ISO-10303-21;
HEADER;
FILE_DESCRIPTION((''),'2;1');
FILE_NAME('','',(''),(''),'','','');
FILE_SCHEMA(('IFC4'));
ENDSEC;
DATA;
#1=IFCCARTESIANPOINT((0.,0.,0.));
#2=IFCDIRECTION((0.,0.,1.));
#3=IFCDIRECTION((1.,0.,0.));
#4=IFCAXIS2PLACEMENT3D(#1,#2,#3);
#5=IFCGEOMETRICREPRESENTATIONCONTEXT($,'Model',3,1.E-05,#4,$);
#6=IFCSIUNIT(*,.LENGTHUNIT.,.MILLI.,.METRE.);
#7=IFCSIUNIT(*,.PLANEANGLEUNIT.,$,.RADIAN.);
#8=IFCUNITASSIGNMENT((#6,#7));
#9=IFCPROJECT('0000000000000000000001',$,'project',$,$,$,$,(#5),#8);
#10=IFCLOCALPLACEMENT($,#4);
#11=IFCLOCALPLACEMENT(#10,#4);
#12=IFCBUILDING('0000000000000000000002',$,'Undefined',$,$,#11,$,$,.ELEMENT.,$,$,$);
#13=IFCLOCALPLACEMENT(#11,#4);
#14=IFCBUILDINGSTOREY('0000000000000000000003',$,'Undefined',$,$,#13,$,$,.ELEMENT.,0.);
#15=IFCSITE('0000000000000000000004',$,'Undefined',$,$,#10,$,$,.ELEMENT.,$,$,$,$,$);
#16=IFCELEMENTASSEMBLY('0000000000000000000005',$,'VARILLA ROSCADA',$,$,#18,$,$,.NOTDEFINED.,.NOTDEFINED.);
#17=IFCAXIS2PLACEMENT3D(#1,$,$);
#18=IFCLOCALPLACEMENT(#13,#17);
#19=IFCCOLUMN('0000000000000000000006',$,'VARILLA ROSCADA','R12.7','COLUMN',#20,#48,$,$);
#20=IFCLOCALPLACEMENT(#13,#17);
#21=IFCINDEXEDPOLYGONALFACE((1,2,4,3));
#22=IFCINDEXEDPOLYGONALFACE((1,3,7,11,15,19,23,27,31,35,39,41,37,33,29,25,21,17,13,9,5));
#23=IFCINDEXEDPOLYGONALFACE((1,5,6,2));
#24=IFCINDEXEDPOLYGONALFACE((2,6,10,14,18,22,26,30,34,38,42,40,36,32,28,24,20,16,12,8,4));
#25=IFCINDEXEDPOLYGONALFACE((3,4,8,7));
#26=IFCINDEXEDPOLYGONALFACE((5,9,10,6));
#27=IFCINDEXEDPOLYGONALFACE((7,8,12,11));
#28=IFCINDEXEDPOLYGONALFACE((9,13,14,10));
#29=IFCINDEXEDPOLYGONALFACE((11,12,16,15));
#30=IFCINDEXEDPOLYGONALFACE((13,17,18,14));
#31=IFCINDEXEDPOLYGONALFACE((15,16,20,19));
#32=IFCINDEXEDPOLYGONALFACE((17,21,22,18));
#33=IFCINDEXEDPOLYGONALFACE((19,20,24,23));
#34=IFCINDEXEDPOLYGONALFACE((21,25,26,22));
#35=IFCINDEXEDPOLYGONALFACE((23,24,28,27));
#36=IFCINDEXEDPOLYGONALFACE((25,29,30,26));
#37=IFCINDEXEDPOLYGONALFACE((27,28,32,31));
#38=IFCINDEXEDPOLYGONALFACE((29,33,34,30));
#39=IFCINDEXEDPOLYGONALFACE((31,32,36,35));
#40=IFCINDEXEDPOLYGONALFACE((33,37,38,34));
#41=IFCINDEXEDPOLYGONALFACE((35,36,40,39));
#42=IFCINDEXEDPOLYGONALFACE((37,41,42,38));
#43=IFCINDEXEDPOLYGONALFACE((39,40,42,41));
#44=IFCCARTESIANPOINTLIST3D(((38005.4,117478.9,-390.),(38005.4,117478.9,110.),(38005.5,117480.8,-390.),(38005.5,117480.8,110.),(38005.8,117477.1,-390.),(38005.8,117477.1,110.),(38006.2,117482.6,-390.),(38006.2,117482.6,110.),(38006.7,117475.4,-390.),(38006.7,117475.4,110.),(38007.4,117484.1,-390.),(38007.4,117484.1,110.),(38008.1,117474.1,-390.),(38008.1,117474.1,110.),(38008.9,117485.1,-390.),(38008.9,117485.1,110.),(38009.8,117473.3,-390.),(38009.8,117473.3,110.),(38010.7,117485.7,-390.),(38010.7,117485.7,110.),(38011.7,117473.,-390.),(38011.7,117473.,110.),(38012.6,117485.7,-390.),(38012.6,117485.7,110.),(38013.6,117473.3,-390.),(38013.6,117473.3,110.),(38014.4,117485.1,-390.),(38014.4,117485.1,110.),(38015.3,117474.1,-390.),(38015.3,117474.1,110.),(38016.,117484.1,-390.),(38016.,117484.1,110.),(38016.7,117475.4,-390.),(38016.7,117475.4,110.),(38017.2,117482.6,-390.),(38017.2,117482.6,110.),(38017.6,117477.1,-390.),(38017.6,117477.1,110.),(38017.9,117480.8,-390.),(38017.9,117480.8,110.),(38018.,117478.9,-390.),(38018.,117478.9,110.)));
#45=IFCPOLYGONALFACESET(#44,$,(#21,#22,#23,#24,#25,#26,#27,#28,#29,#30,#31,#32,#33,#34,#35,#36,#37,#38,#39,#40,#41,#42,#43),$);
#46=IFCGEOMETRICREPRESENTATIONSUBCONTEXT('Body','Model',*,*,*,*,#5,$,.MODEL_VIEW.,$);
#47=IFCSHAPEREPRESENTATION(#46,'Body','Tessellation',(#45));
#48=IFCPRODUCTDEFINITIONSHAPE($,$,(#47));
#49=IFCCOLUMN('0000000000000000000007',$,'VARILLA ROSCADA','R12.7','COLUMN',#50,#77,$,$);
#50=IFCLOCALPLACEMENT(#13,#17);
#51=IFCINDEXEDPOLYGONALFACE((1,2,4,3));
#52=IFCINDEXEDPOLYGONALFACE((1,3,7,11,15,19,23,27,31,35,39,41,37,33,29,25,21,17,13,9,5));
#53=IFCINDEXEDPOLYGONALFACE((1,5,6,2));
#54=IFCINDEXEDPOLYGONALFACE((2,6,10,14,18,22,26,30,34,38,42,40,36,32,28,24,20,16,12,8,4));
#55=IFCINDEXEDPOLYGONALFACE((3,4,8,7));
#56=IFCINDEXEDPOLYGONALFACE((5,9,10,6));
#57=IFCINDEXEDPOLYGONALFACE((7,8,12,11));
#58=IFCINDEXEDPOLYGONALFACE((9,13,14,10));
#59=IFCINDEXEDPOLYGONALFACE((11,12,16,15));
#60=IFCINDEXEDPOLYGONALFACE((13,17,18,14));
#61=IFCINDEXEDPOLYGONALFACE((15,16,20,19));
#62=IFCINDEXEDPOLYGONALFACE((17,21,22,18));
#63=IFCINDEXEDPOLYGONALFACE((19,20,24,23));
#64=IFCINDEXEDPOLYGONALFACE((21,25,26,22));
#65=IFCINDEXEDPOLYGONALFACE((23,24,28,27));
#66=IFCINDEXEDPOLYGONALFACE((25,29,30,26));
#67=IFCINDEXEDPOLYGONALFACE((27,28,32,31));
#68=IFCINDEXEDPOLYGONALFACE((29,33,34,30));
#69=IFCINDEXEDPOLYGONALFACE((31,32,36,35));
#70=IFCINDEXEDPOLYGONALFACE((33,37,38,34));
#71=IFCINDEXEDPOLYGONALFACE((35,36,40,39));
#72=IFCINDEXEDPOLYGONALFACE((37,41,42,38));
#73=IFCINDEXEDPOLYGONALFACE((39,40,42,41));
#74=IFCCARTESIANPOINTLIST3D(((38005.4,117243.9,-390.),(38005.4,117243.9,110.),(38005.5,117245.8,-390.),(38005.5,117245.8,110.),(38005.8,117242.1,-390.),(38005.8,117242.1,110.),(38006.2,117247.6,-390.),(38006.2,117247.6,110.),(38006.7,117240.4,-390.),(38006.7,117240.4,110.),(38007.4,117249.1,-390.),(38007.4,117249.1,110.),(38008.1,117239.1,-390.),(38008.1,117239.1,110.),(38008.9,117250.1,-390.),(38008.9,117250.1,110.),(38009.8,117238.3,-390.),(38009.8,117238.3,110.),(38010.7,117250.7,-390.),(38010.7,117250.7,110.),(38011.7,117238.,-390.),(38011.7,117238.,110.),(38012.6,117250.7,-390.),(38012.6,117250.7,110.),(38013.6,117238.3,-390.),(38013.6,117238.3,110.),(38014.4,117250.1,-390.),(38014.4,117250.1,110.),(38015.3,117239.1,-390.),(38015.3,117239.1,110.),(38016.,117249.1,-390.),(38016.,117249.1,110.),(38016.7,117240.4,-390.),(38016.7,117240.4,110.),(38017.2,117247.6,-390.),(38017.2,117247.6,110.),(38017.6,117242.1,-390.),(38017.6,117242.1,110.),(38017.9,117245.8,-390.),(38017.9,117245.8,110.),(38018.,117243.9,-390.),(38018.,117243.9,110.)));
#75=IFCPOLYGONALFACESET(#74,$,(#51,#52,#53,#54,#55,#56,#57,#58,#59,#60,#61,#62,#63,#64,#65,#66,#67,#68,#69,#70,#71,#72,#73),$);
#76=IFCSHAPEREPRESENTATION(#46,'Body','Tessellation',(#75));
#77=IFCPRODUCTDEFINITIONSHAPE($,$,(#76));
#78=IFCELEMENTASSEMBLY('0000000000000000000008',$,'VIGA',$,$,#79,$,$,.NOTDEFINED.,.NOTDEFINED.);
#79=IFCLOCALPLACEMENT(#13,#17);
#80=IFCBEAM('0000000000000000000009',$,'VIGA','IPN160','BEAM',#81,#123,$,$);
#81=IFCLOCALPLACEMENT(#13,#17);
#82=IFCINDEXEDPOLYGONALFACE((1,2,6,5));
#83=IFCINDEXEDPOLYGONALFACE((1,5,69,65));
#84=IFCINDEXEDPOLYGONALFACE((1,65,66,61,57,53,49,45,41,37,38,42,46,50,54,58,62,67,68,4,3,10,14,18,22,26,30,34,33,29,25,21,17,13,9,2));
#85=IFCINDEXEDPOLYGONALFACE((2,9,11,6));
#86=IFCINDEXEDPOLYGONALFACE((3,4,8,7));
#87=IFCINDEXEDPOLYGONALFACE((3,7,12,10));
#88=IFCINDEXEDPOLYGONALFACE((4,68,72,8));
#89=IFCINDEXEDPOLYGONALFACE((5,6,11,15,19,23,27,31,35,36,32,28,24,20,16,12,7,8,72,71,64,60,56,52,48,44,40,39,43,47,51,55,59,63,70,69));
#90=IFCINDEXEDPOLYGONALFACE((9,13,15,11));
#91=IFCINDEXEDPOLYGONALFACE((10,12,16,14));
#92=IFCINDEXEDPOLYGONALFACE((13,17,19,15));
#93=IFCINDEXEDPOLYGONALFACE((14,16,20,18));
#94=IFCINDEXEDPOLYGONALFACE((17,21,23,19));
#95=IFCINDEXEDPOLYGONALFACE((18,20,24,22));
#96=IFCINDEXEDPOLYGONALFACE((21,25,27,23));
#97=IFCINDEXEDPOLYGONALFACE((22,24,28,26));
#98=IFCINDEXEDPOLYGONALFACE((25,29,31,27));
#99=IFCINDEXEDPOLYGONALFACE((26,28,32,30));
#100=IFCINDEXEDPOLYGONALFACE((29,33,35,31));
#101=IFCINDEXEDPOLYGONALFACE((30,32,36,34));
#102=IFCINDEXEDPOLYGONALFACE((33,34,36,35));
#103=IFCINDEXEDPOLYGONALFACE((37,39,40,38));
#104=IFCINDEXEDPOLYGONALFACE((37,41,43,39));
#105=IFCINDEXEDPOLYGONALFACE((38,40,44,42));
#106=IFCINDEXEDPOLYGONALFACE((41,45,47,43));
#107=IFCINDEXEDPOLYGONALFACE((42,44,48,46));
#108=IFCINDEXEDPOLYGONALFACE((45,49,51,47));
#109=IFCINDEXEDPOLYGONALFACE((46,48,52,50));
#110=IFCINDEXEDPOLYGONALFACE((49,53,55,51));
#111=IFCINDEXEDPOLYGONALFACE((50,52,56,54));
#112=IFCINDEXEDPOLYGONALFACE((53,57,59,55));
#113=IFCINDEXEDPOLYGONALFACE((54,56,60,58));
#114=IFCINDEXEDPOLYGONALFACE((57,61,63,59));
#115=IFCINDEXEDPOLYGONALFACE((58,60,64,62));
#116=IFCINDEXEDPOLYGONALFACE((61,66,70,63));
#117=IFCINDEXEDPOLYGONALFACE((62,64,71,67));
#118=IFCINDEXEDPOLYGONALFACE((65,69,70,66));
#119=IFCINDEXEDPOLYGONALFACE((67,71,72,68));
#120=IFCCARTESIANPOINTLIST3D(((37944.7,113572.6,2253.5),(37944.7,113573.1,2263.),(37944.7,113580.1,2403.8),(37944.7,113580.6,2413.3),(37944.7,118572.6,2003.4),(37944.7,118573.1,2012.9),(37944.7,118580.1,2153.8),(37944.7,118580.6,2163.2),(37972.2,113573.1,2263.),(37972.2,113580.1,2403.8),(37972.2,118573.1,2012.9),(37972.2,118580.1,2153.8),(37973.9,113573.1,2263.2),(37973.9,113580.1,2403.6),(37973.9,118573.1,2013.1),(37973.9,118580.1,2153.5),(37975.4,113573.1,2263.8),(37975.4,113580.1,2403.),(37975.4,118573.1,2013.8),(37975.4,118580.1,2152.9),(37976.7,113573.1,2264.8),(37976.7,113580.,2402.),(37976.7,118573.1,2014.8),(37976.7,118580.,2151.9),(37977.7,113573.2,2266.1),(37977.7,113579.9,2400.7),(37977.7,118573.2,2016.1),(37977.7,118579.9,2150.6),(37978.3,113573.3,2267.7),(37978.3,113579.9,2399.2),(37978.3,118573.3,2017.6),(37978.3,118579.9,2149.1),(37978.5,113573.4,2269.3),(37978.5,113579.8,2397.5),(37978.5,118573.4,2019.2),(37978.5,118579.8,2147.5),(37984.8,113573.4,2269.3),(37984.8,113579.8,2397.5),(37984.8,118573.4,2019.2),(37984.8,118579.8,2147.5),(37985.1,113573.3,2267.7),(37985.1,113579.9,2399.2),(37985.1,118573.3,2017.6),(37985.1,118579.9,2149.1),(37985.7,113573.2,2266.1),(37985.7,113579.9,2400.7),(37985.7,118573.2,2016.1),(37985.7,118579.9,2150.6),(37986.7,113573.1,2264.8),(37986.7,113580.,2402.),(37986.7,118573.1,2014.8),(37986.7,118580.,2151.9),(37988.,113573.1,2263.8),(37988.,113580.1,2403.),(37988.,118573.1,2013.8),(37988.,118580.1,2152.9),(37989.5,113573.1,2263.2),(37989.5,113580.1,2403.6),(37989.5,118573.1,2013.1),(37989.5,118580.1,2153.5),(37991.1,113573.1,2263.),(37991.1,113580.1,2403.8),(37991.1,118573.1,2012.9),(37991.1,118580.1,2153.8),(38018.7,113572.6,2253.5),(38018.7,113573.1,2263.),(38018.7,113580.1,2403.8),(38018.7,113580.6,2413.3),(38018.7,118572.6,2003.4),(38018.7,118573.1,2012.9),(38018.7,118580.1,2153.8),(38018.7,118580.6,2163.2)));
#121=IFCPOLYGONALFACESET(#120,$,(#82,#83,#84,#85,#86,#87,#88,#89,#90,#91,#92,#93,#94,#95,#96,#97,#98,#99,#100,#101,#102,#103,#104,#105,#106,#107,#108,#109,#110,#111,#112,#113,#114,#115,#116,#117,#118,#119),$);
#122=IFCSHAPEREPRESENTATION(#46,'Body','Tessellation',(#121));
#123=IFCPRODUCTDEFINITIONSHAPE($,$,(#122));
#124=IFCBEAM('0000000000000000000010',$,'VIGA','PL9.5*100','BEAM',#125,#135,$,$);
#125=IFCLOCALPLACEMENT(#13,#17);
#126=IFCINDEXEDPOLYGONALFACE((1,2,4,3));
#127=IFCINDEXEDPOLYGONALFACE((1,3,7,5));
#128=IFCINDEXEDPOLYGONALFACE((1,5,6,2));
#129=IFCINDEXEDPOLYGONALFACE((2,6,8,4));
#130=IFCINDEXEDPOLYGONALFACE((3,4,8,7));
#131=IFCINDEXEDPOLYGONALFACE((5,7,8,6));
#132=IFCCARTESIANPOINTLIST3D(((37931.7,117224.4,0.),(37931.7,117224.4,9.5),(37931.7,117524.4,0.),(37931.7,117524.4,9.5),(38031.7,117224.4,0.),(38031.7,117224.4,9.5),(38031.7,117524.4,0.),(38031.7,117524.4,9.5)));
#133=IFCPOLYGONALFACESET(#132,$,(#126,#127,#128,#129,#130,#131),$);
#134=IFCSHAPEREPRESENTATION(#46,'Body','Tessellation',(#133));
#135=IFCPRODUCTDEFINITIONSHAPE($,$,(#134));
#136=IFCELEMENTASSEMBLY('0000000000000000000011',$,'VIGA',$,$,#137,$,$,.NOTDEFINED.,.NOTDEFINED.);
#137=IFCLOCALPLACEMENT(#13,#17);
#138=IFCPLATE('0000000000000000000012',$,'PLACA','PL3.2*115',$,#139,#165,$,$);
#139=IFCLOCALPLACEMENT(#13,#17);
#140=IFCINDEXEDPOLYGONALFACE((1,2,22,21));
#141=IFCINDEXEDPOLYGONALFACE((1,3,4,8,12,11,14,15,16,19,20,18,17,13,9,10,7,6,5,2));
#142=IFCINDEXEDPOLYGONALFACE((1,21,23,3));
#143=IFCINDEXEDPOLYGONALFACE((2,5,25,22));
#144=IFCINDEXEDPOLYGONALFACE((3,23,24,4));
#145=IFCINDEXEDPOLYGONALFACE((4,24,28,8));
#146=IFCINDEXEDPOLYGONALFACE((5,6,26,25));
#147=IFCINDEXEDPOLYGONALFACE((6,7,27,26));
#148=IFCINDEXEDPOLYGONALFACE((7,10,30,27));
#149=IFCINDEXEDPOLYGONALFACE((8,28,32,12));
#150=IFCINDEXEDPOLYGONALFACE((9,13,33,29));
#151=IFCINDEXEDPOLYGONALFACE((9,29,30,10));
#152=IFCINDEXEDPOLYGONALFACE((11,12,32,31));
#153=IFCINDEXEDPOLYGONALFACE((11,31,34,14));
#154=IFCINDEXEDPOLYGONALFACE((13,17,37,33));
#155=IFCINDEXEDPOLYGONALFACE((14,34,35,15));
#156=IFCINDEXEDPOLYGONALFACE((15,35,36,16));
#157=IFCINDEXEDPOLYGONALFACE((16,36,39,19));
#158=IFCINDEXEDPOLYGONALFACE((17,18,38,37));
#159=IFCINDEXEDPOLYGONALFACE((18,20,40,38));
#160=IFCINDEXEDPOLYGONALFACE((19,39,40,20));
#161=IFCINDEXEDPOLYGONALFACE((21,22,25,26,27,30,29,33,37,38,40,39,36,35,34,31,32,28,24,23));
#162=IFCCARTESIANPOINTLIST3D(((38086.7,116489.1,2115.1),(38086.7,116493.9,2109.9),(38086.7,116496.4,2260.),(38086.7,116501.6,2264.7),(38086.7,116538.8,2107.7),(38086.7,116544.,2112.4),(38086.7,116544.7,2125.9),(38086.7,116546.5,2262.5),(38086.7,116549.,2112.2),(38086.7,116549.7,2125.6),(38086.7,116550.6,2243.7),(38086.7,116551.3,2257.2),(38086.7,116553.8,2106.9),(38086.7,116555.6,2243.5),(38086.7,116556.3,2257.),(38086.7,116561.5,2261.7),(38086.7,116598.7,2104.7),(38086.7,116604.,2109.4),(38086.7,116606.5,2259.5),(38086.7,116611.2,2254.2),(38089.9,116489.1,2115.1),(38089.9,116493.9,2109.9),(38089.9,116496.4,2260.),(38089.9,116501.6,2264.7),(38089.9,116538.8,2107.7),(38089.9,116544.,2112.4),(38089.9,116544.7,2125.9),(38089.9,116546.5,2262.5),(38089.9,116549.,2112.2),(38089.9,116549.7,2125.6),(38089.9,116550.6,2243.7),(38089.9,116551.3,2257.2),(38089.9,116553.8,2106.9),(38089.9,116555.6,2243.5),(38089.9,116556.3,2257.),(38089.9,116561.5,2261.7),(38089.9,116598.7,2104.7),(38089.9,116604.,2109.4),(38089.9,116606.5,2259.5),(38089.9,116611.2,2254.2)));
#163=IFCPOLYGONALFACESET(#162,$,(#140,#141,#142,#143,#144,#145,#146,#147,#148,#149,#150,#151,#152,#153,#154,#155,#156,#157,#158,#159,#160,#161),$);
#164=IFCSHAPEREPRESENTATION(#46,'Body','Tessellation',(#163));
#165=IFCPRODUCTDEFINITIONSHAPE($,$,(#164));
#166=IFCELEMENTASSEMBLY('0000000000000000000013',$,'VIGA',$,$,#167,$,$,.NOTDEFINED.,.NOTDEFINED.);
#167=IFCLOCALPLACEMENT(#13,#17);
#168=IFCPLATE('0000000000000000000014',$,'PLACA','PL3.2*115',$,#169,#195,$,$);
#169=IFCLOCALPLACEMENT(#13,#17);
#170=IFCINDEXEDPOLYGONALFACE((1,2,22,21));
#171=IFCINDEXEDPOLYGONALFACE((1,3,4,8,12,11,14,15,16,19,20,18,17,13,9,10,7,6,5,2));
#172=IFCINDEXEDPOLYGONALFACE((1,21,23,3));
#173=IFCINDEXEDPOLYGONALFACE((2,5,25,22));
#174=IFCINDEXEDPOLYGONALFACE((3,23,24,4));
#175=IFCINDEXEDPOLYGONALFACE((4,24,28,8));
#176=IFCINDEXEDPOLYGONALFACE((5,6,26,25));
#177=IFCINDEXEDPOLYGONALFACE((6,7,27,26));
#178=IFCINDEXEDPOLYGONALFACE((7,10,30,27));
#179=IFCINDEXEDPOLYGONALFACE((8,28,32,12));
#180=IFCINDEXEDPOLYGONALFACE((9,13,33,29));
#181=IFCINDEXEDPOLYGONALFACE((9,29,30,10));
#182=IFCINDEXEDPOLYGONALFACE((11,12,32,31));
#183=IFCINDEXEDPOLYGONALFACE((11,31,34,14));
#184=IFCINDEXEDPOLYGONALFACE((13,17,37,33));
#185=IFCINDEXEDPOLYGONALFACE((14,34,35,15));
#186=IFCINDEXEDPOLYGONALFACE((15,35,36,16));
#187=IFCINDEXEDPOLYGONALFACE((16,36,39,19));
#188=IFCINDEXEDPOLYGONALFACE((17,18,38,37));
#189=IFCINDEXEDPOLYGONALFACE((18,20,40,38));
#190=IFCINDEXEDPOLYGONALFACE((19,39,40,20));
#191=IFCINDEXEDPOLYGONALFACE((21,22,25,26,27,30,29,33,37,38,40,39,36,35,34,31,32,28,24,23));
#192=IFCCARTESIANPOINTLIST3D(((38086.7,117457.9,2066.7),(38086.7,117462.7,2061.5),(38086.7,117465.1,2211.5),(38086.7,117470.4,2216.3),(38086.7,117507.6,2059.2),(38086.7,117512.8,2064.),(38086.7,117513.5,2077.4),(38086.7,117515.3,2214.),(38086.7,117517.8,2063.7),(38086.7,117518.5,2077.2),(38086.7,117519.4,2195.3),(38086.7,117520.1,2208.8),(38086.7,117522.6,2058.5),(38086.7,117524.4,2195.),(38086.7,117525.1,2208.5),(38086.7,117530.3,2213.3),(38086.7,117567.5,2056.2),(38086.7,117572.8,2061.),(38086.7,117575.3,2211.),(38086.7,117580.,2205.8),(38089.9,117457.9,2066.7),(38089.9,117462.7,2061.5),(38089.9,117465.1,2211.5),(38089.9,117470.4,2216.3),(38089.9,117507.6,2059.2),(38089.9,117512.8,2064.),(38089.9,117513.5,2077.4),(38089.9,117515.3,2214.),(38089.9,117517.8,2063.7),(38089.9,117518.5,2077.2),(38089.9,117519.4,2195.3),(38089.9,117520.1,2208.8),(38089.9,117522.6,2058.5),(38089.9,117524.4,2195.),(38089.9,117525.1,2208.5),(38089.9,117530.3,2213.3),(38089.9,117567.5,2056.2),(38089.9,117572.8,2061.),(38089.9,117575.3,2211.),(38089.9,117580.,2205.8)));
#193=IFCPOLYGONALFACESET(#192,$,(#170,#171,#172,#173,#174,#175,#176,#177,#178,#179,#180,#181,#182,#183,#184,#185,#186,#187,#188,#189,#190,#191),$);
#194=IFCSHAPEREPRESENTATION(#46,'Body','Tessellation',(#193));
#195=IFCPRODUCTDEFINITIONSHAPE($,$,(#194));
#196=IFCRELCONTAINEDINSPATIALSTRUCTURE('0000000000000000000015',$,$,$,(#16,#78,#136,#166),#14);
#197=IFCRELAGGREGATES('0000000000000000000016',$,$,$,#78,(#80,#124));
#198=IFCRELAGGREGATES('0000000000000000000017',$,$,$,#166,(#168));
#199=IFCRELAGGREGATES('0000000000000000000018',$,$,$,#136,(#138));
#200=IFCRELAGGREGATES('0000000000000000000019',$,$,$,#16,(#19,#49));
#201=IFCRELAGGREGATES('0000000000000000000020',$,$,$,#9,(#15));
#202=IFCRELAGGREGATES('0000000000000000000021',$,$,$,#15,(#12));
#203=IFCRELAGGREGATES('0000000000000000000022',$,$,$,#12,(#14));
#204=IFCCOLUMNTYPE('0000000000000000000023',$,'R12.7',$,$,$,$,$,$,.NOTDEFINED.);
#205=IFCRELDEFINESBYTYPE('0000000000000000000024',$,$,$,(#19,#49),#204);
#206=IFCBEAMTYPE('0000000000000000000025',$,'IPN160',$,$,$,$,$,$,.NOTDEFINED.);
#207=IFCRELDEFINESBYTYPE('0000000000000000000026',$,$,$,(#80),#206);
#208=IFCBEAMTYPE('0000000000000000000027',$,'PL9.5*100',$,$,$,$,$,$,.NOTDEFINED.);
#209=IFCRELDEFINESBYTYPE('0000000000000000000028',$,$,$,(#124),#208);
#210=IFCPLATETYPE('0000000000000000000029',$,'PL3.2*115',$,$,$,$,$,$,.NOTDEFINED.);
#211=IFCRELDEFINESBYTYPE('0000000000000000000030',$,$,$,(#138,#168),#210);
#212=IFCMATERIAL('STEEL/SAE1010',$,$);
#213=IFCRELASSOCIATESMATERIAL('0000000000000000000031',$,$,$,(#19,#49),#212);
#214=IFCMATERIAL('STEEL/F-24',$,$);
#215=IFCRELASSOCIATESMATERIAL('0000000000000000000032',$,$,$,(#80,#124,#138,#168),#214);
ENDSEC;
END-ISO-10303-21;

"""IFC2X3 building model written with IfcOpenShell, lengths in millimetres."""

from ifc_helpers import new_model, si_unit, frame, origin_with_axes, origin_2d_with_axis, place, context, subcontext, project, spatial, polyline, rectangle, circle, i_section, outline, extrude, material, type_object, element, aggregate, save


model = new_model("IFC2X3")

# Units and contexts
model_context = context("Model", 3, precision=1e-05, world=origin_with_axes())
body_context = subcontext(model_context, "Body", "Model", "MODEL_VIEW")
ifc_project = project(units=[si_unit("LENGTHUNIT", "METRE", prefix="MILLI"), si_unit("PLANEANGLEUNIT", "RADIAN")], contexts=[model_context])

# Site, building, storey
site_placement = place(None, origin_with_axes())
site = spatial("IfcSite", under=ifc_project, at=site_placement, Name="Undefined", CompositionType="ELEMENT")
building_placement = place(site_placement, origin_with_axes())
building = spatial("IfcBuilding", under=site, at=building_placement, Name="Undefined", CompositionType="ELEMENT")
storey_placement = place(building_placement, origin_with_axes())
storey = spatial("IfcBuildingStorey", under=building, at=storey_placement, Name="Undefined", CompositionType="ELEMENT", Elevation=0.0)

# Element assembly, columns
assembly_1_placement = place(storey_placement, origin_with_axes())
assembly_1 = element("IfcElementAssembly", 1, at=assembly_1_placement, inside=storey, Name="VARILLA ROSCADA", AssemblyPlace="NOTDEFINED", PredefinedType="NOTDEFINED")
ifc_material_1 = material(Name="STEEL/SAE1010")
column_type = type_object("IfcColumnType", Name="R12.7", PredefinedType="NOTDEFINED")
column_1_placement = place(assembly_1_placement, frame((38011.7, 117479.4, -390.0), z_axis=(0.0, 0.0, 1.0), x_axis=(-1.0, 0.0, 0.0)))
column_1 = element("IfcColumn", 2, at=column_1_placement, type_object=column_type, material=ifc_material_1, Name="VARILLA ROSCADA", Description="R12.7", ObjectType="COLUMN", context=body_context, shape_type="SweptSolid", body=[
    extrude(circle(Radius=6.3, at=origin_2d_with_axis()), frame((0.0, 0.0, 500.0), z_axis=(0.0, 0.0, -1.0), x_axis=(0.0, 1.0, 0.0)), (0.0, 0.0, 1.0), 500.0),
])
column_2_placement = place(assembly_1_placement, frame((38011.7, 117244.4, -390.0), z_axis=(0.0, 0.0, 1.0), x_axis=(-1.0, 0.0, 0.0)))
column_2 = element("IfcColumn", 3, at=column_2_placement, type_object=column_type, material=ifc_material_1, Name="VARILLA ROSCADA", Description="R12.7", ObjectType="COLUMN", context=body_context, shape_type="SweptSolid", body=[
    extrude(circle(Radius=6.3, at=origin_2d_with_axis()), frame((0.0, 0.0, 500.0), z_axis=(0.0, 0.0, -1.0), x_axis=(0.0, 1.0, 0.0)), (0.0, 0.0, 1.0), 500.0),
])

# Element assembly, beams
assembly_2_placement = place(storey_placement, origin_with_axes())
assembly_2 = element("IfcElementAssembly", 4, at=assembly_2_placement, inside=storey, Name="VIGA", AssemblyPlace="NOTDEFINED", PredefinedType="NOTDEFINED")
ifc_material_2 = material(Name="STEEL/F-24")
beam_type_1 = type_object("IfcBeamType", Name="IPN160", PredefinedType="NOTDEFINED")
beam_1_placement = place(assembly_2_placement, frame((37981.7, 118576.6, 2083.3), z_axis=(0.0, 0.04995, 0.998752), x_axis=(0.0, -0.998752, 0.04995)))
beam_1 = element("IfcBeam", 5, at=beam_1_placement, type_object=beam_type_1, material=ifc_material_2, Name="VIGA", Description="IPN160", ObjectType="BEAM", context=body_context, shape_type="SweptSolid", body=[
    extrude(i_section(OverallWidth=74.0, OverallDepth=160.0, WebThickness=6.3, FlangeThickness=9.5, FilletRadius=6.3, at=origin_2d_with_axis()), frame((5006.2, 0.0, 0.0), z_axis=(-1.0, 0.0, 0.0), x_axis=(0.0, -1.0, 0.0)), (0.0, 0.0, 1.0), 5006.2),
])
beam_type_2 = type_object("IfcBeamType", Name="PL9.5*100", PredefinedType="NOTDEFINED")
beam_2_placement = place(assembly_2_placement, frame((37981.7, 117524.4, 4.7), z_axis=(1.0, 0.0, 0.0), x_axis=(0.0, -1.0, 0.0)))
beam_2 = element("IfcBeam", 6, at=beam_2_placement, type_object=beam_type_2, material=ifc_material_2, Name="VIGA", Description="PL9.5*100", ObjectType="BEAM", context=body_context, shape_type="SweptSolid", body=[
    extrude(rectangle(XDim=9.5, YDim=100.0, at=origin_2d_with_axis()), frame((300.0, 0.0, 0.0), z_axis=(-1.0, 0.0, 0.0), x_axis=(0.0, -1.0, 0.0)), (0.0, 0.0, 1.0), 300.0),
])

# Element assemblies, plates
assembly_3_placement = place(storey_placement, origin_with_axes())
assembly_3 = element("IfcElementAssembly", 7, at=assembly_3_placement, inside=storey, Name="VIGA", AssemblyPlace="NOTDEFINED", PredefinedType="NOTDEFINED")
plate_type_1 = type_object("IfcPlateType", Name="PL3.2*115", PredefinedType="NOTDEFINED")
plate_1_placement = place(assembly_3_placement, frame((38088.3, 116611.5, 2259.2), z_axis=(1.0, 0.0, 0.0), x_axis=(0.0, -0.998752, 0.04995)))
plate_1 = element("IfcPlate", 8, at=plate_1_placement, type_object=plate_type_1, material=ifc_material_2, Name="PLACA", Description="PL3.2*115", context=body_context, shape_type="SweptSolid", body=[
    extrude(outline(polyline([(0.0, 5.0), (5.0, 0.0), (50.0, 0.0), (55.0, 5.0), (55.0, 18.5), (60.0, 18.5), (60.0, 5.0), (65.0, 0.0), (110.0, 0.0), (115.0, 5.0), (115.0, 150.0), (110.0, 155.0), (65.0, 155.0), (60.0, 150.0), (60.0, 136.5), (55.0, 136.5), (55.0, 150.0), (50.0, 155.0), (5.0, 155.0), (0.0, 150.0), (0.0, 5.0)])), frame((0.0, 0.0, -1.6), z_axis=(0.0, 0.0, 1.0), x_axis=(1.0, 0.0, 0.0)), (0.0, 0.0, 1.0), 3.2),
])
assembly_4_placement = place(storey_placement, origin_with_axes())
assembly_4 = element("IfcElementAssembly", 9, at=assembly_4_placement, inside=storey, Name="VIGA", AssemblyPlace="NOTDEFINED", PredefinedType="NOTDEFINED")
plate_2_placement = place(assembly_4_placement, frame((38088.3, 117580.3, 2210.8), z_axis=(1.0, 0.0, 0.0), x_axis=(0.0, -0.998752, 0.04995)))
plate_2 = element("IfcPlate", 10, at=plate_2_placement, type_object=plate_type_1, material=ifc_material_2, Name="PLACA", Description="PL3.2*115", context=body_context, shape_type="SweptSolid", body=[
    extrude(outline(polyline([(0.0, 5.0), (5.0, 0.0), (50.0, 0.0), (55.0, 5.0), (55.0, 18.5), (60.0, 18.5), (60.0, 5.0), (65.0, 0.0), (110.0, 0.0), (115.0, 5.0), (115.0, 150.0), (110.0, 155.0), (65.0, 155.0), (60.0, 150.0), (60.0, 136.5), (55.0, 136.5), (55.0, 150.0), (50.0, 155.0), (5.0, 155.0), (0.0, 150.0), (0.0, 5.0)])), frame((0.0, 0.0, -1.6), z_axis=(0.0, 0.0, 1.0), x_axis=(1.0, 0.0, 0.0)), (0.0, 0.0, 1.0), 3.2),
])

aggregate(assembly_2, [beam_1, beam_2])

aggregate(assembly_4, [plate_2])
aggregate(assembly_3, [plate_1])
aggregate(assembly_1, [column_1, column_2])

save(model, "model.ifc")
